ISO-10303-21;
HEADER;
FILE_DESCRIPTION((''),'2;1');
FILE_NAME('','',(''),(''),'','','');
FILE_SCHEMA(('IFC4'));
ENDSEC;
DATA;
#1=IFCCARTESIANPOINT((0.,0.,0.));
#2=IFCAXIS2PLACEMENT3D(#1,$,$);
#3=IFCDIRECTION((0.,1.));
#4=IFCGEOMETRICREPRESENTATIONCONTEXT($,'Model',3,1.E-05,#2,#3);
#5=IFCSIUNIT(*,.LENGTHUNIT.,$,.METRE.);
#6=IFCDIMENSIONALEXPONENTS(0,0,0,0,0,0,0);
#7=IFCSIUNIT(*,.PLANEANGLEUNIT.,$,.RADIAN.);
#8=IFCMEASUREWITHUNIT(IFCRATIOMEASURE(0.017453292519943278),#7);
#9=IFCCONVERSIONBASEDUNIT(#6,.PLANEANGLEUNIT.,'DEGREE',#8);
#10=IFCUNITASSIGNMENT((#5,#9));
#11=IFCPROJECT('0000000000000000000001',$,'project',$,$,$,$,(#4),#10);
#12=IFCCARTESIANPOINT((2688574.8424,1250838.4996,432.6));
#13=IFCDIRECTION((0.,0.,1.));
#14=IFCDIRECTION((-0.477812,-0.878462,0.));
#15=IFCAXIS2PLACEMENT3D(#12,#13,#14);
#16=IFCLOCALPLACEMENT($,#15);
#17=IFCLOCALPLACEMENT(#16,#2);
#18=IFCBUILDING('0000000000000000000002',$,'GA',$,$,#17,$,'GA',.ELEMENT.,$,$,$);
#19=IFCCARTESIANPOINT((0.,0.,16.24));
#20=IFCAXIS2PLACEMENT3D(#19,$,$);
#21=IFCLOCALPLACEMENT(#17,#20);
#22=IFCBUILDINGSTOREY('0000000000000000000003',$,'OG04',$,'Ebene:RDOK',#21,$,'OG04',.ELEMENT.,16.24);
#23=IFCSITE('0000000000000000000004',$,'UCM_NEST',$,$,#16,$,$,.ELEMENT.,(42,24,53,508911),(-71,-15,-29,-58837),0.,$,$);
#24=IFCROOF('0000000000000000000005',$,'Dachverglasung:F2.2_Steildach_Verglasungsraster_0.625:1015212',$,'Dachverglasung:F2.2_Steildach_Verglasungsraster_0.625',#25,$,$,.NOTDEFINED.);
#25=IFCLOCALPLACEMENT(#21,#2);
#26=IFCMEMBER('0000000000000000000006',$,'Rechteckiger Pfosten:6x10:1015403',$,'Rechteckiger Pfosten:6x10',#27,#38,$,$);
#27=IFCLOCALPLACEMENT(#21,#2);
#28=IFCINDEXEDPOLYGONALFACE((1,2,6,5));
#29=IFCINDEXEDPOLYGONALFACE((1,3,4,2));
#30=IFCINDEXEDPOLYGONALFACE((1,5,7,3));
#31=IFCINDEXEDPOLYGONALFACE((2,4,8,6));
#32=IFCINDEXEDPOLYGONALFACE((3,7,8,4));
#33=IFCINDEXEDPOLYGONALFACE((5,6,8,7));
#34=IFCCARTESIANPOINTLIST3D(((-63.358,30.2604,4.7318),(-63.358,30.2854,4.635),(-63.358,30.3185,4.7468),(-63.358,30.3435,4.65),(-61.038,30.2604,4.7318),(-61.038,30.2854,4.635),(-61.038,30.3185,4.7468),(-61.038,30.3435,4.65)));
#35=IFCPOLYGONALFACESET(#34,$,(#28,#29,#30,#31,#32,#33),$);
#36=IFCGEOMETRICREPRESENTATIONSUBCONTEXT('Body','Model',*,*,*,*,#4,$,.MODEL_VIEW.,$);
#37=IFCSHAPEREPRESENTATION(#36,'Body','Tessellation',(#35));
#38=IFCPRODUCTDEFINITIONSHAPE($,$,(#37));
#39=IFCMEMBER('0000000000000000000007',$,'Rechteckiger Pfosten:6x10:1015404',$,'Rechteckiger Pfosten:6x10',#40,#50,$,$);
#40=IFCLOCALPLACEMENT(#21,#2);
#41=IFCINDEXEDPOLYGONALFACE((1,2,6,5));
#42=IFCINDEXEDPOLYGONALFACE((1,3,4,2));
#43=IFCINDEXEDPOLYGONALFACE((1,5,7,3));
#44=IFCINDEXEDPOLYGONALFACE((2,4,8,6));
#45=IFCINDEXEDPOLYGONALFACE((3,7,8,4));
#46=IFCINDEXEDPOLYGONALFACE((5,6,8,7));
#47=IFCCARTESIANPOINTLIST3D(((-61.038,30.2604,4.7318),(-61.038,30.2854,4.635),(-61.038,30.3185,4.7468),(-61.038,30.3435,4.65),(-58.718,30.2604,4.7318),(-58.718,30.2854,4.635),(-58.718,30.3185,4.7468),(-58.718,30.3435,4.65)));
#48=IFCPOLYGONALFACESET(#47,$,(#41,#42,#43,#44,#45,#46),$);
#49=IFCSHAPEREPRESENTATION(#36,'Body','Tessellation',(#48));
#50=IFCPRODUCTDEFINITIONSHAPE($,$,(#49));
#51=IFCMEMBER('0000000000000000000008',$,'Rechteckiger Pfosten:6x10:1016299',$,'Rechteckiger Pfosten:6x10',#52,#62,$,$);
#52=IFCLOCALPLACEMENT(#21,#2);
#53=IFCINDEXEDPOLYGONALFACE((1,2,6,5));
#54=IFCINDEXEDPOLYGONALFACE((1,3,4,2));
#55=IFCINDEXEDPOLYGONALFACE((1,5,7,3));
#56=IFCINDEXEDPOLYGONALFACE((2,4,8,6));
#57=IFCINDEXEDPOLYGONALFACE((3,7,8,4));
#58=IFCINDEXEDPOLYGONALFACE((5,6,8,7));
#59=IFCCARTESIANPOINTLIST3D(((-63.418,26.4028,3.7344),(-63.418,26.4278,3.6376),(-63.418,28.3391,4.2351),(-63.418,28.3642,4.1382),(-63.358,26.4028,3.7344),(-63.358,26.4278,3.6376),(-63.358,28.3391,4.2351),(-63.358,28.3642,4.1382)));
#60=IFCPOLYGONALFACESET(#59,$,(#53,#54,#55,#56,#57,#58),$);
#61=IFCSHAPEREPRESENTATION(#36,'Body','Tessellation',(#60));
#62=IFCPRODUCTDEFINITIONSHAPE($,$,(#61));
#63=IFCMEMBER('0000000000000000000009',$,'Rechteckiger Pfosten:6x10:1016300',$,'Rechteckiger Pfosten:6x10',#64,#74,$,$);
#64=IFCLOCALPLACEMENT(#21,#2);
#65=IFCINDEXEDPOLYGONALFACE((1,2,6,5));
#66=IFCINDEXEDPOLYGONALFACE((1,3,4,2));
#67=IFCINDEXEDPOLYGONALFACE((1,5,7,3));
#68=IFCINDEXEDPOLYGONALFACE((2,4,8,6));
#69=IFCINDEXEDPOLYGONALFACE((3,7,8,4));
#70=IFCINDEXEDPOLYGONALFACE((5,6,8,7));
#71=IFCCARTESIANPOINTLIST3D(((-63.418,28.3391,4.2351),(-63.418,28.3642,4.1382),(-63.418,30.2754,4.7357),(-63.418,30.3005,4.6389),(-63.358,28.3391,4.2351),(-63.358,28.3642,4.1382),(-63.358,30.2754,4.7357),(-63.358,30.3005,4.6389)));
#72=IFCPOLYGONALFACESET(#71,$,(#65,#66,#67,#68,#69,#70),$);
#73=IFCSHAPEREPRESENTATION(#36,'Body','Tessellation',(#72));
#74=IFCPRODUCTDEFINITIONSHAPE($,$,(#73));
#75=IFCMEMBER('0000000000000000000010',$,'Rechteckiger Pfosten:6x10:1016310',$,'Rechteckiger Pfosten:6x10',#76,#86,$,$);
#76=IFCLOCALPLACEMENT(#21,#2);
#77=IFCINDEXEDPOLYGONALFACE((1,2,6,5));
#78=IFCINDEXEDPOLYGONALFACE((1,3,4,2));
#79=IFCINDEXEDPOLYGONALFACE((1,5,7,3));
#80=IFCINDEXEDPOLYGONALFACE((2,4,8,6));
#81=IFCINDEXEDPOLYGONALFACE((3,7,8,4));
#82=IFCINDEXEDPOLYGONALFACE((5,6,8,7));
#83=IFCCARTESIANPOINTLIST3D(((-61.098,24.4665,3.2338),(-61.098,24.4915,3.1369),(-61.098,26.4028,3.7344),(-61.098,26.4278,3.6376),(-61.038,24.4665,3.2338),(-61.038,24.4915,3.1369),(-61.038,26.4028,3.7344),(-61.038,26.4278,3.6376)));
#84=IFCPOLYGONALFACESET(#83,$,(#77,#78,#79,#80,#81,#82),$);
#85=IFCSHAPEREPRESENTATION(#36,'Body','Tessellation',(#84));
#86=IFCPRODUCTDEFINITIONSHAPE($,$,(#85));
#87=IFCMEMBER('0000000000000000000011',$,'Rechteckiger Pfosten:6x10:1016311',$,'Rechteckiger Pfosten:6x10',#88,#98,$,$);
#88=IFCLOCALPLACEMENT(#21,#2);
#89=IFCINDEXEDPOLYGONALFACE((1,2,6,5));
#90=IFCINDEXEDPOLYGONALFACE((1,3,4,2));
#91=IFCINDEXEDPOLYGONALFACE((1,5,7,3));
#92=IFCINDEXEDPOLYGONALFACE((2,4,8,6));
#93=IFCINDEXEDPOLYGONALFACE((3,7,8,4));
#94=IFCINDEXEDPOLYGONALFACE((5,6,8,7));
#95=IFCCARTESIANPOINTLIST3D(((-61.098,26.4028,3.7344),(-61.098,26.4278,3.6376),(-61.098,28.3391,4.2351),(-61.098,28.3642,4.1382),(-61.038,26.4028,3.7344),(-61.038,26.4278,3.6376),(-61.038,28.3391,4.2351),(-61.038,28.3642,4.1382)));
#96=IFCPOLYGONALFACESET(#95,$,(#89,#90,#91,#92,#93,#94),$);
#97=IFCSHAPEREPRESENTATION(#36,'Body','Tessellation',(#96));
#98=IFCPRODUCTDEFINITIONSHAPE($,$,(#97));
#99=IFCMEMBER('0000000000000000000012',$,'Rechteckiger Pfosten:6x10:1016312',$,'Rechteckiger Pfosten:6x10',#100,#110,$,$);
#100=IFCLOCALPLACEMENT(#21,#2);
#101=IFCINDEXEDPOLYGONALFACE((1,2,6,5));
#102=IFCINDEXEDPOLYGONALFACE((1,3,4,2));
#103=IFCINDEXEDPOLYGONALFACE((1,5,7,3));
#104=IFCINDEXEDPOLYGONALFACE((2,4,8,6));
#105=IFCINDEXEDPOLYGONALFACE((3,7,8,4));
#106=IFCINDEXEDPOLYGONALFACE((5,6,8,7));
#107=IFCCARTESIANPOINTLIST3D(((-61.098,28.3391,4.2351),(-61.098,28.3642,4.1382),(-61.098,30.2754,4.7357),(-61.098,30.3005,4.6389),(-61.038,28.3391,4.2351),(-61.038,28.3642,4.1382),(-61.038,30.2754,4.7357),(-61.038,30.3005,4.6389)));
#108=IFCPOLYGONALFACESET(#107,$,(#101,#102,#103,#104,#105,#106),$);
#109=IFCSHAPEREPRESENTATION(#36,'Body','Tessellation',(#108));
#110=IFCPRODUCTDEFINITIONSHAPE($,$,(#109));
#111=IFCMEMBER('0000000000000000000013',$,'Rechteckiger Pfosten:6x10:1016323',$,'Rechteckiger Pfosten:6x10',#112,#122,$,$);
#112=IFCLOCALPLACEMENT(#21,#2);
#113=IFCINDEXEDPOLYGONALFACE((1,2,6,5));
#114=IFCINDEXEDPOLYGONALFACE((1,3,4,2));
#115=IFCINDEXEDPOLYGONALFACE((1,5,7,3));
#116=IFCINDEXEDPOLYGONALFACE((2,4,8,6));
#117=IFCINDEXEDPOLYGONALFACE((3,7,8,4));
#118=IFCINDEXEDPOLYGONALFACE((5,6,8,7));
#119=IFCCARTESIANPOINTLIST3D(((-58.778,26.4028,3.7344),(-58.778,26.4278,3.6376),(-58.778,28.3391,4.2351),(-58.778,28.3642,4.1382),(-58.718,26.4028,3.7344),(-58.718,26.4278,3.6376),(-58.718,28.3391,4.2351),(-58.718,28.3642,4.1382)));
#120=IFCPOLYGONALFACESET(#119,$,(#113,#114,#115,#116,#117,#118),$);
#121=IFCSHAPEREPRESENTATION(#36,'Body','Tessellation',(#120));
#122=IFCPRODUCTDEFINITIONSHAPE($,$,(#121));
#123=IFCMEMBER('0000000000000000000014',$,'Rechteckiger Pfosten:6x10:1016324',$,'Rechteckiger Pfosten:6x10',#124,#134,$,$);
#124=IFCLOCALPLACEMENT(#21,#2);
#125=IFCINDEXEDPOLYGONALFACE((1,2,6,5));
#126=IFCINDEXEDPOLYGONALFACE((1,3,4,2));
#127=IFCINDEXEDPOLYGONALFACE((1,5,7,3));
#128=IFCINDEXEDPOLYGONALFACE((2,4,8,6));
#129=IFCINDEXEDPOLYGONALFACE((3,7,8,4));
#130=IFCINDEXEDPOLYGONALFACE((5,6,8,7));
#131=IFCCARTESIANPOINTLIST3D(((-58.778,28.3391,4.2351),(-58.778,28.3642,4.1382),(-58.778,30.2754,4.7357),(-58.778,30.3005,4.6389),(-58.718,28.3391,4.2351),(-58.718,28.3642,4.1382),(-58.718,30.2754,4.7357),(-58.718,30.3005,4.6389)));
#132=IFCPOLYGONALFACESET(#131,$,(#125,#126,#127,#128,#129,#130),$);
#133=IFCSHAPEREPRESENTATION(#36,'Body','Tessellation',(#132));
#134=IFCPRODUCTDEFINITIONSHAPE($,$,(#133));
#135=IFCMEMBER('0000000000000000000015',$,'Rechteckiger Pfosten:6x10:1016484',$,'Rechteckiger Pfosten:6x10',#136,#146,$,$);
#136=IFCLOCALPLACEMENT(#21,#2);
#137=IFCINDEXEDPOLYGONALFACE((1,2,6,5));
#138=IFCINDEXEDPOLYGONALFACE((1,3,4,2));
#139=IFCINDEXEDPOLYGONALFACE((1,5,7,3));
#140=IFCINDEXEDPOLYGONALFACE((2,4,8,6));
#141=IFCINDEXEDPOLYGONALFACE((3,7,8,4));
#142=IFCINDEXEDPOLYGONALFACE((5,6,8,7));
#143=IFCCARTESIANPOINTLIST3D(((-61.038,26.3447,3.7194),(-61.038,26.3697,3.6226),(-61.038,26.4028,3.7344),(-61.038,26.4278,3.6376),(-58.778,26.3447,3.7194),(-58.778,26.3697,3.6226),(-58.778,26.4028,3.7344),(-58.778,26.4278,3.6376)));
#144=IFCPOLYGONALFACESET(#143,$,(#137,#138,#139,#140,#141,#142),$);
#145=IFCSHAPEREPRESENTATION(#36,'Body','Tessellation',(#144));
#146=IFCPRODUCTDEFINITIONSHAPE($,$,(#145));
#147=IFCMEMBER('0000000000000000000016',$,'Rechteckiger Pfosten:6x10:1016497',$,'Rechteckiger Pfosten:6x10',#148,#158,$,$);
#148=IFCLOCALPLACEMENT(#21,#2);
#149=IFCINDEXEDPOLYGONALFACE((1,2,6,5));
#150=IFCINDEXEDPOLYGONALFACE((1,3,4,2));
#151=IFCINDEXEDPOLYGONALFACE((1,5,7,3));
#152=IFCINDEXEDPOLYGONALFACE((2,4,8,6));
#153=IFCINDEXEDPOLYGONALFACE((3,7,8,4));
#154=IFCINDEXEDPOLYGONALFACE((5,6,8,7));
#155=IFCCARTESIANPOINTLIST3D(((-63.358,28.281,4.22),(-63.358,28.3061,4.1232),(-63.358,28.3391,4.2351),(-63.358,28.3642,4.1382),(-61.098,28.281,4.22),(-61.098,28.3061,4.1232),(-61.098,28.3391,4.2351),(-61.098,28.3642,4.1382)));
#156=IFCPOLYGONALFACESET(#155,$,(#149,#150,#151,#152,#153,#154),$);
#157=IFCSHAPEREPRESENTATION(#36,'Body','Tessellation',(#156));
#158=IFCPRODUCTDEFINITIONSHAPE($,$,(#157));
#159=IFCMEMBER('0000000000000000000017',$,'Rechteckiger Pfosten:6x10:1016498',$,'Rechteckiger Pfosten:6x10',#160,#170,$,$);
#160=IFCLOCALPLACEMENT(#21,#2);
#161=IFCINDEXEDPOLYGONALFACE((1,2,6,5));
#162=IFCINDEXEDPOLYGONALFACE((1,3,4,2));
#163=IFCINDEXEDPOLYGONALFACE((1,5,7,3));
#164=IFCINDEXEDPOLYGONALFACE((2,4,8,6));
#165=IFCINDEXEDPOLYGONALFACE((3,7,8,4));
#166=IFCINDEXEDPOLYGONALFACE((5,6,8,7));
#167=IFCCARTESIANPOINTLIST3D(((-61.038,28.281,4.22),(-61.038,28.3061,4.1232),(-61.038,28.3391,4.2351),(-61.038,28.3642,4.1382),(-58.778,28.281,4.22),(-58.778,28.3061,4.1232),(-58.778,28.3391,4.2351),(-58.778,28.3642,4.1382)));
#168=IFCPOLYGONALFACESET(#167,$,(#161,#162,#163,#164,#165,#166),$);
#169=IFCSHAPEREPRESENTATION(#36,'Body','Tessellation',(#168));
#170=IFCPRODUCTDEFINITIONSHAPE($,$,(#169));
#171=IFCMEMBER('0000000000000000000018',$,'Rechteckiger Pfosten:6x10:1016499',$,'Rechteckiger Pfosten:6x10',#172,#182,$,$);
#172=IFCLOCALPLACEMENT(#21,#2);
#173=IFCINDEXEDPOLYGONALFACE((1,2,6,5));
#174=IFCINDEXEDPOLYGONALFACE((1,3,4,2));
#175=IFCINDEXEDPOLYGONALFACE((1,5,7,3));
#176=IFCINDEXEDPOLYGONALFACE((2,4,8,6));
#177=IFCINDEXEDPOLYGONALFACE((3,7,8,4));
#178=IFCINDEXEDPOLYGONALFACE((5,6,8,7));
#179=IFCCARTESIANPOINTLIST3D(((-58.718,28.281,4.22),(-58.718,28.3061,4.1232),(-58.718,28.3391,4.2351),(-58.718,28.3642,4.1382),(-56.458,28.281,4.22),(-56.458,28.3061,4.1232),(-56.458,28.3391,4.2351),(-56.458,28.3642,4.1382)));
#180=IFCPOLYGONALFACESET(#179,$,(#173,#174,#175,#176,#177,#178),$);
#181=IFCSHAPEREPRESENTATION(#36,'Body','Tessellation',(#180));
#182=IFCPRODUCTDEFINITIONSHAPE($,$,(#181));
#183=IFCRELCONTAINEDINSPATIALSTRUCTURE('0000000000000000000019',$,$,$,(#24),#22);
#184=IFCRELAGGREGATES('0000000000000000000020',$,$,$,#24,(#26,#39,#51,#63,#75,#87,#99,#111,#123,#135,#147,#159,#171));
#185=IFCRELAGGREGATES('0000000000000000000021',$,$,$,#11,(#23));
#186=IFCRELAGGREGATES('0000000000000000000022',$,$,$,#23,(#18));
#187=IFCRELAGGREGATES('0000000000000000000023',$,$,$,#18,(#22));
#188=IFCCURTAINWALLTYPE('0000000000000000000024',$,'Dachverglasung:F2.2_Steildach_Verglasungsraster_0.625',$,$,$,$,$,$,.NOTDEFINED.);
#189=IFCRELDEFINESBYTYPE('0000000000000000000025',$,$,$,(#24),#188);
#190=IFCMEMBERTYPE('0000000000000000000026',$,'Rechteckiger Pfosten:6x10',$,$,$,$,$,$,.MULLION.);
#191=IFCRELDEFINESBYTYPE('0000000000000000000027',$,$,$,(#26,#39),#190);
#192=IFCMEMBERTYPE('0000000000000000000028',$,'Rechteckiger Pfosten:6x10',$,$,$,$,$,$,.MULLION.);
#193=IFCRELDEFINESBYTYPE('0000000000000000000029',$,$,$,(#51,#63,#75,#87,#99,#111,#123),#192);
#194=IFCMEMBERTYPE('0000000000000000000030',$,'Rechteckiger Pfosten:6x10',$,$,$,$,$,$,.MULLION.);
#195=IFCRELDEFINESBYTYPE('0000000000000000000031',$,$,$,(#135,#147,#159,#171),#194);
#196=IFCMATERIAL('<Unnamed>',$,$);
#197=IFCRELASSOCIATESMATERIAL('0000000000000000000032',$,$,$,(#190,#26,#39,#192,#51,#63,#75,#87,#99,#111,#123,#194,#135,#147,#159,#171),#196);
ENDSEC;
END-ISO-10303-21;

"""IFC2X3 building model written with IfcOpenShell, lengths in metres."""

from ifc_helpers import new_model, entity, si_unit, converted_unit, direction, frame, origin, origin_2d_with_axis, place, context, subcontext, project, spatial, rectangle, extrude, source, transform, mapped, material, type_object, type_shapes, element, aggregate, save


model = new_model("IFC2X3")

# Units and contexts
model_context = context("Model", 3, precision=1e-05, world=origin(), true_north=direction((0.0, 1.0)))
body_context = subcontext(model_context, "Body", "Model", "MODEL_VIEW")
ifc_project = project(units=[si_unit("LENGTHUNIT", "METRE"), converted_unit("PLANEANGLEUNIT", "DEGREE", entity("IfcRatioMeasure", 0.017453292519943278), si_unit("PLANEANGLEUNIT", "RADIAN"), dimensions=[0, 0, 0, 0, 0, 0, 0])], contexts=[model_context])

# Site, building, storey
site_placement = place(None, frame((2688574.8424, 1250838.4996, 432.6), z_axis=(0.0, 0.0, 1.0), x_axis=(-0.477812, -0.878462, 0.0)))
site = spatial("IfcSite", under=ifc_project, at=site_placement, Name="UCM_NEST", CompositionType="ELEMENT", RefLatitude=(42, 24, 53, 508911), RefLongitude=(-71, -15, -29, -58837), RefElevation=0.0)
building_placement = place(site_placement, origin())
building = spatial("IfcBuilding", under=site, at=building_placement, Name="GA", LongName="GA", CompositionType="ELEMENT")
storey_placement = place(building_placement, frame((0.0, 0.0, 16.24)))
storey = spatial("IfcBuildingStorey", under=building, at=storey_placement, Name="OG04", ObjectType="Ebene:RDOK", LongName="OG04", CompositionType="ELEMENT", Elevation=16.24)

# Roof, members
curtain_wall_type = type_object("IfcCurtainWallType", Name="Dachverglasung:F2.2_Steildach_Verglasungsraster_0.625", PredefinedType="NOTDEFINED")
roof_placement = place(storey_placement, frame((0.0, 0.0, -16.24)))
roof = element("IfcRoof", 1, at=roof_placement, inside=storey, type_object=curtain_wall_type, Name="Dachverglasung:F2.2_Steildach_Verglasungsraster_0.625:1015212", ObjectType="Dachverglasung:F2.2_Steildach_Verglasungsraster_0.625", ShapeType="NOTDEFINED")
ifc_material_1 = material(Name="<Unnamed>")
member_type_1 = type_object("IfcMemberType", Name="Rechteckiger Pfosten:6x10", PredefinedType="MULLION", material=ifc_material_1)
shared_shape_1 = source(origin(), body_context, "Body", "SweptSolid", [
    extrude(rectangle(XDim=0.1, YDim=0.06, at=origin_2d_with_axis()), frame((-0.03, -0.05, -2.32), z_axis=(0.0, 0.0, 1.0), x_axis=(0.0, -1.0, 0.0)), (0.0, 0.0, 1.0), 2.32),
])
type_shapes(member_type_1, [shared_shape_1])
member_1_placement = place(roof_placement, frame((-63.358, 30.3435, 20.89), z_axis=(-1.0, 0.0, 0.0), x_axis=(0.0, 0.968163, 0.250322)))
member_1 = element("IfcMember", 2, at=member_1_placement, type_object=member_type_1, material=ifc_material_1, Name="Rechteckiger Pfosten:6x10:1015403", ObjectType="Rechteckiger Pfosten:6x10", context=body_context, shape_type="MappedRepresentation", body=[
    mapped(shared_shape_1, transform((0.0, 0.0, 0.0), scale=1.0)),
])
member_2_placement = place(roof_placement, frame((-61.038, 30.3435, 20.89), z_axis=(-1.0, 0.0, 0.0), x_axis=(0.0, 0.968163, 0.250322)))
member_2 = element("IfcMember", 3, at=member_2_placement, type_object=member_type_1, material=ifc_material_1, Name="Rechteckiger Pfosten:6x10:1015404", ObjectType="Rechteckiger Pfosten:6x10", context=body_context, shape_type="MappedRepresentation", body=[
    mapped(shared_shape_1, transform((0.0, 0.0, 0.0), scale=1.0)),
])
member_type_2 = type_object("IfcMemberType", Name="Rechteckiger Pfosten:6x10", PredefinedType="MULLION", material=ifc_material_1)
shared_shape_2 = source(origin(), body_context, "Body", "SweptSolid", [
    extrude(rectangle(XDim=0.1, YDim=0.06, at=origin_2d_with_axis()), frame((-0.03, -0.05, -2.0), z_axis=(0.0, 0.0, 1.0), x_axis=(0.0, -1.0, 0.0)), (0.0, 0.0, 1.0), 2.0),
])
type_shapes(member_type_2, [shared_shape_2])
member_3_placement = place(roof_placement, frame((-63.358, 28.3642, 20.3782), z_axis=(0.0, 0.968163, 0.250322), x_axis=(1.0, 0.0, 0.0)))
member_3 = element("IfcMember", 4, at=member_3_placement, type_object=member_type_2, material=ifc_material_1, Name="Rechteckiger Pfosten:6x10:1016299", ObjectType="Rechteckiger Pfosten:6x10", context=body_context, shape_type="MappedRepresentation", body=[
    mapped(shared_shape_2, transform((0.0, 0.0, 0.0), scale=1.0)),
])
member_4_placement = place(roof_placement, frame((-63.358, 30.3005, 20.8789), z_axis=(0.0, 0.968163, 0.250322), x_axis=(1.0, 0.0, 0.0)))
member_4 = element("IfcMember", 5, at=member_4_placement, type_object=member_type_2, material=ifc_material_1, Name="Rechteckiger Pfosten:6x10:1016300", ObjectType="Rechteckiger Pfosten:6x10", context=body_context, shape_type="MappedRepresentation", body=[
    mapped(shared_shape_2, transform((0.0, 0.0, 0.0), scale=1.0)),
])
member_5_placement = place(roof_placement, frame((-61.038, 26.4278, 19.8776), z_axis=(0.0, 0.968163, 0.250322), x_axis=(1.0, 0.0, 0.0)))
member_5 = element("IfcMember", 6, at=member_5_placement, type_object=member_type_2, material=ifc_material_1, Name="Rechteckiger Pfosten:6x10:1016310", ObjectType="Rechteckiger Pfosten:6x10", context=body_context, shape_type="MappedRepresentation", body=[
    mapped(shared_shape_2, transform((0.0, 0.0, 0.0), scale=1.0)),
])
member_6_placement = place(roof_placement, frame((-61.038, 28.3642, 20.3782), z_axis=(0.0, 0.968163, 0.250322), x_axis=(1.0, 0.0, 0.0)))
member_6 = element("IfcMember", 7, at=member_6_placement, type_object=member_type_2, material=ifc_material_1, Name="Rechteckiger Pfosten:6x10:1016311", ObjectType="Rechteckiger Pfosten:6x10", context=body_context, shape_type="MappedRepresentation", body=[
    mapped(shared_shape_2, transform((0.0, 0.0, 0.0), scale=1.0)),
])
member_7_placement = place(roof_placement, frame((-61.038, 30.3005, 20.8789), z_axis=(0.0, 0.968163, 0.250322), x_axis=(1.0, 0.0, 0.0)))
member_7 = element("IfcMember", 8, at=member_7_placement, type_object=member_type_2, material=ifc_material_1, Name="Rechteckiger Pfosten:6x10:1016312", ObjectType="Rechteckiger Pfosten:6x10", context=body_context, shape_type="MappedRepresentation", body=[
    mapped(shared_shape_2, transform((0.0, 0.0, 0.0), scale=1.0)),
])
member_8_placement = place(roof_placement, frame((-58.718, 28.3642, 20.3782), z_axis=(0.0, 0.968163, 0.250322), x_axis=(1.0, 0.0, 0.0)))
member_8 = element("IfcMember", 9, at=member_8_placement, type_object=member_type_2, material=ifc_material_1, Name="Rechteckiger Pfosten:6x10:1016323", ObjectType="Rechteckiger Pfosten:6x10", context=body_context, shape_type="MappedRepresentation", body=[
    mapped(shared_shape_2, transform((0.0, 0.0, 0.0), scale=1.0)),
])
member_9_placement = place(roof_placement, frame((-58.718, 30.3005, 20.8789), z_axis=(0.0, 0.968163, 0.250322), x_axis=(1.0, 0.0, 0.0)))
member_9 = element("IfcMember", 10, at=member_9_placement, type_object=member_type_2, material=ifc_material_1, Name="Rechteckiger Pfosten:6x10:1016324", ObjectType="Rechteckiger Pfosten:6x10", context=body_context, shape_type="MappedRepresentation", body=[
    mapped(shared_shape_2, transform((0.0, 0.0, 0.0), scale=1.0)),
])
member_type_3 = type_object("IfcMemberType", Name="Rechteckiger Pfosten:6x10", PredefinedType="MULLION", material=ifc_material_1)
shared_shape_3 = source(origin(), body_context, "Body", "SweptSolid", [
    extrude(rectangle(XDim=0.1, YDim=0.06, at=origin_2d_with_axis()), frame((-0.03, -0.05, -2.26), z_axis=(0.0, 0.0, 1.0), x_axis=(0.0, -1.0, 0.0)), (0.0, 0.0, 1.0), 2.26),
])
type_shapes(member_type_3, [shared_shape_3])
member_10_placement = place(roof_placement, frame((-61.038, 26.4278, 19.8776), z_axis=(-1.0, 0.0, 0.0), x_axis=(0.0, 0.968163, 0.250322)))
member_10 = element("IfcMember", 11, at=member_10_placement, type_object=member_type_3, material=ifc_material_1, Name="Rechteckiger Pfosten:6x10:1016484", ObjectType="Rechteckiger Pfosten:6x10", context=body_context, shape_type="MappedRepresentation", body=[
    mapped(shared_shape_3, transform((0.0, 0.0, 0.0), scale=1.0)),
])
member_11_placement = place(roof_placement, frame((-63.358, 28.3642, 20.3782), z_axis=(-1.0, 0.0, 0.0), x_axis=(0.0, 0.968163, 0.250322)))
member_11 = element("IfcMember", 12, at=member_11_placement, type_object=member_type_3, material=ifc_material_1, Name="Rechteckiger Pfosten:6x10:1016497", ObjectType="Rechteckiger Pfosten:6x10", context=body_context, shape_type="MappedRepresentation", body=[
    mapped(shared_shape_3, transform((0.0, 0.0, 0.0), scale=1.0)),
])
member_12_placement = place(roof_placement, frame((-61.038, 28.3642, 20.3782), z_axis=(-1.0, 0.0, 0.0), x_axis=(0.0, 0.968163, 0.250322)))
member_12 = element("IfcMember", 13, at=member_12_placement, type_object=member_type_3, material=ifc_material_1, Name="Rechteckiger Pfosten:6x10:1016498", ObjectType="Rechteckiger Pfosten:6x10", context=body_context, shape_type="MappedRepresentation", body=[
    mapped(shared_shape_3, transform((0.0, 0.0, 0.0), scale=1.0)),
])
member_13_placement = place(roof_placement, frame((-58.718, 28.3642, 20.3782), z_axis=(-1.0, 0.0, 0.0), x_axis=(0.0, 0.968163, 0.250322)))
member_13 = element("IfcMember", 14, at=member_13_placement, type_object=member_type_3, material=ifc_material_1, Name="Rechteckiger Pfosten:6x10:1016499", ObjectType="Rechteckiger Pfosten:6x10", context=body_context, shape_type="MappedRepresentation", body=[
    mapped(shared_shape_3, transform((0.0, 0.0, 0.0), scale=1.0)),
])
aggregate(roof, [member_1, member_2, member_3, member_4, member_5, member_6, member_7, member_8, member_9, member_10, member_11, member_12, member_13])

save(model, "model.ifc")
